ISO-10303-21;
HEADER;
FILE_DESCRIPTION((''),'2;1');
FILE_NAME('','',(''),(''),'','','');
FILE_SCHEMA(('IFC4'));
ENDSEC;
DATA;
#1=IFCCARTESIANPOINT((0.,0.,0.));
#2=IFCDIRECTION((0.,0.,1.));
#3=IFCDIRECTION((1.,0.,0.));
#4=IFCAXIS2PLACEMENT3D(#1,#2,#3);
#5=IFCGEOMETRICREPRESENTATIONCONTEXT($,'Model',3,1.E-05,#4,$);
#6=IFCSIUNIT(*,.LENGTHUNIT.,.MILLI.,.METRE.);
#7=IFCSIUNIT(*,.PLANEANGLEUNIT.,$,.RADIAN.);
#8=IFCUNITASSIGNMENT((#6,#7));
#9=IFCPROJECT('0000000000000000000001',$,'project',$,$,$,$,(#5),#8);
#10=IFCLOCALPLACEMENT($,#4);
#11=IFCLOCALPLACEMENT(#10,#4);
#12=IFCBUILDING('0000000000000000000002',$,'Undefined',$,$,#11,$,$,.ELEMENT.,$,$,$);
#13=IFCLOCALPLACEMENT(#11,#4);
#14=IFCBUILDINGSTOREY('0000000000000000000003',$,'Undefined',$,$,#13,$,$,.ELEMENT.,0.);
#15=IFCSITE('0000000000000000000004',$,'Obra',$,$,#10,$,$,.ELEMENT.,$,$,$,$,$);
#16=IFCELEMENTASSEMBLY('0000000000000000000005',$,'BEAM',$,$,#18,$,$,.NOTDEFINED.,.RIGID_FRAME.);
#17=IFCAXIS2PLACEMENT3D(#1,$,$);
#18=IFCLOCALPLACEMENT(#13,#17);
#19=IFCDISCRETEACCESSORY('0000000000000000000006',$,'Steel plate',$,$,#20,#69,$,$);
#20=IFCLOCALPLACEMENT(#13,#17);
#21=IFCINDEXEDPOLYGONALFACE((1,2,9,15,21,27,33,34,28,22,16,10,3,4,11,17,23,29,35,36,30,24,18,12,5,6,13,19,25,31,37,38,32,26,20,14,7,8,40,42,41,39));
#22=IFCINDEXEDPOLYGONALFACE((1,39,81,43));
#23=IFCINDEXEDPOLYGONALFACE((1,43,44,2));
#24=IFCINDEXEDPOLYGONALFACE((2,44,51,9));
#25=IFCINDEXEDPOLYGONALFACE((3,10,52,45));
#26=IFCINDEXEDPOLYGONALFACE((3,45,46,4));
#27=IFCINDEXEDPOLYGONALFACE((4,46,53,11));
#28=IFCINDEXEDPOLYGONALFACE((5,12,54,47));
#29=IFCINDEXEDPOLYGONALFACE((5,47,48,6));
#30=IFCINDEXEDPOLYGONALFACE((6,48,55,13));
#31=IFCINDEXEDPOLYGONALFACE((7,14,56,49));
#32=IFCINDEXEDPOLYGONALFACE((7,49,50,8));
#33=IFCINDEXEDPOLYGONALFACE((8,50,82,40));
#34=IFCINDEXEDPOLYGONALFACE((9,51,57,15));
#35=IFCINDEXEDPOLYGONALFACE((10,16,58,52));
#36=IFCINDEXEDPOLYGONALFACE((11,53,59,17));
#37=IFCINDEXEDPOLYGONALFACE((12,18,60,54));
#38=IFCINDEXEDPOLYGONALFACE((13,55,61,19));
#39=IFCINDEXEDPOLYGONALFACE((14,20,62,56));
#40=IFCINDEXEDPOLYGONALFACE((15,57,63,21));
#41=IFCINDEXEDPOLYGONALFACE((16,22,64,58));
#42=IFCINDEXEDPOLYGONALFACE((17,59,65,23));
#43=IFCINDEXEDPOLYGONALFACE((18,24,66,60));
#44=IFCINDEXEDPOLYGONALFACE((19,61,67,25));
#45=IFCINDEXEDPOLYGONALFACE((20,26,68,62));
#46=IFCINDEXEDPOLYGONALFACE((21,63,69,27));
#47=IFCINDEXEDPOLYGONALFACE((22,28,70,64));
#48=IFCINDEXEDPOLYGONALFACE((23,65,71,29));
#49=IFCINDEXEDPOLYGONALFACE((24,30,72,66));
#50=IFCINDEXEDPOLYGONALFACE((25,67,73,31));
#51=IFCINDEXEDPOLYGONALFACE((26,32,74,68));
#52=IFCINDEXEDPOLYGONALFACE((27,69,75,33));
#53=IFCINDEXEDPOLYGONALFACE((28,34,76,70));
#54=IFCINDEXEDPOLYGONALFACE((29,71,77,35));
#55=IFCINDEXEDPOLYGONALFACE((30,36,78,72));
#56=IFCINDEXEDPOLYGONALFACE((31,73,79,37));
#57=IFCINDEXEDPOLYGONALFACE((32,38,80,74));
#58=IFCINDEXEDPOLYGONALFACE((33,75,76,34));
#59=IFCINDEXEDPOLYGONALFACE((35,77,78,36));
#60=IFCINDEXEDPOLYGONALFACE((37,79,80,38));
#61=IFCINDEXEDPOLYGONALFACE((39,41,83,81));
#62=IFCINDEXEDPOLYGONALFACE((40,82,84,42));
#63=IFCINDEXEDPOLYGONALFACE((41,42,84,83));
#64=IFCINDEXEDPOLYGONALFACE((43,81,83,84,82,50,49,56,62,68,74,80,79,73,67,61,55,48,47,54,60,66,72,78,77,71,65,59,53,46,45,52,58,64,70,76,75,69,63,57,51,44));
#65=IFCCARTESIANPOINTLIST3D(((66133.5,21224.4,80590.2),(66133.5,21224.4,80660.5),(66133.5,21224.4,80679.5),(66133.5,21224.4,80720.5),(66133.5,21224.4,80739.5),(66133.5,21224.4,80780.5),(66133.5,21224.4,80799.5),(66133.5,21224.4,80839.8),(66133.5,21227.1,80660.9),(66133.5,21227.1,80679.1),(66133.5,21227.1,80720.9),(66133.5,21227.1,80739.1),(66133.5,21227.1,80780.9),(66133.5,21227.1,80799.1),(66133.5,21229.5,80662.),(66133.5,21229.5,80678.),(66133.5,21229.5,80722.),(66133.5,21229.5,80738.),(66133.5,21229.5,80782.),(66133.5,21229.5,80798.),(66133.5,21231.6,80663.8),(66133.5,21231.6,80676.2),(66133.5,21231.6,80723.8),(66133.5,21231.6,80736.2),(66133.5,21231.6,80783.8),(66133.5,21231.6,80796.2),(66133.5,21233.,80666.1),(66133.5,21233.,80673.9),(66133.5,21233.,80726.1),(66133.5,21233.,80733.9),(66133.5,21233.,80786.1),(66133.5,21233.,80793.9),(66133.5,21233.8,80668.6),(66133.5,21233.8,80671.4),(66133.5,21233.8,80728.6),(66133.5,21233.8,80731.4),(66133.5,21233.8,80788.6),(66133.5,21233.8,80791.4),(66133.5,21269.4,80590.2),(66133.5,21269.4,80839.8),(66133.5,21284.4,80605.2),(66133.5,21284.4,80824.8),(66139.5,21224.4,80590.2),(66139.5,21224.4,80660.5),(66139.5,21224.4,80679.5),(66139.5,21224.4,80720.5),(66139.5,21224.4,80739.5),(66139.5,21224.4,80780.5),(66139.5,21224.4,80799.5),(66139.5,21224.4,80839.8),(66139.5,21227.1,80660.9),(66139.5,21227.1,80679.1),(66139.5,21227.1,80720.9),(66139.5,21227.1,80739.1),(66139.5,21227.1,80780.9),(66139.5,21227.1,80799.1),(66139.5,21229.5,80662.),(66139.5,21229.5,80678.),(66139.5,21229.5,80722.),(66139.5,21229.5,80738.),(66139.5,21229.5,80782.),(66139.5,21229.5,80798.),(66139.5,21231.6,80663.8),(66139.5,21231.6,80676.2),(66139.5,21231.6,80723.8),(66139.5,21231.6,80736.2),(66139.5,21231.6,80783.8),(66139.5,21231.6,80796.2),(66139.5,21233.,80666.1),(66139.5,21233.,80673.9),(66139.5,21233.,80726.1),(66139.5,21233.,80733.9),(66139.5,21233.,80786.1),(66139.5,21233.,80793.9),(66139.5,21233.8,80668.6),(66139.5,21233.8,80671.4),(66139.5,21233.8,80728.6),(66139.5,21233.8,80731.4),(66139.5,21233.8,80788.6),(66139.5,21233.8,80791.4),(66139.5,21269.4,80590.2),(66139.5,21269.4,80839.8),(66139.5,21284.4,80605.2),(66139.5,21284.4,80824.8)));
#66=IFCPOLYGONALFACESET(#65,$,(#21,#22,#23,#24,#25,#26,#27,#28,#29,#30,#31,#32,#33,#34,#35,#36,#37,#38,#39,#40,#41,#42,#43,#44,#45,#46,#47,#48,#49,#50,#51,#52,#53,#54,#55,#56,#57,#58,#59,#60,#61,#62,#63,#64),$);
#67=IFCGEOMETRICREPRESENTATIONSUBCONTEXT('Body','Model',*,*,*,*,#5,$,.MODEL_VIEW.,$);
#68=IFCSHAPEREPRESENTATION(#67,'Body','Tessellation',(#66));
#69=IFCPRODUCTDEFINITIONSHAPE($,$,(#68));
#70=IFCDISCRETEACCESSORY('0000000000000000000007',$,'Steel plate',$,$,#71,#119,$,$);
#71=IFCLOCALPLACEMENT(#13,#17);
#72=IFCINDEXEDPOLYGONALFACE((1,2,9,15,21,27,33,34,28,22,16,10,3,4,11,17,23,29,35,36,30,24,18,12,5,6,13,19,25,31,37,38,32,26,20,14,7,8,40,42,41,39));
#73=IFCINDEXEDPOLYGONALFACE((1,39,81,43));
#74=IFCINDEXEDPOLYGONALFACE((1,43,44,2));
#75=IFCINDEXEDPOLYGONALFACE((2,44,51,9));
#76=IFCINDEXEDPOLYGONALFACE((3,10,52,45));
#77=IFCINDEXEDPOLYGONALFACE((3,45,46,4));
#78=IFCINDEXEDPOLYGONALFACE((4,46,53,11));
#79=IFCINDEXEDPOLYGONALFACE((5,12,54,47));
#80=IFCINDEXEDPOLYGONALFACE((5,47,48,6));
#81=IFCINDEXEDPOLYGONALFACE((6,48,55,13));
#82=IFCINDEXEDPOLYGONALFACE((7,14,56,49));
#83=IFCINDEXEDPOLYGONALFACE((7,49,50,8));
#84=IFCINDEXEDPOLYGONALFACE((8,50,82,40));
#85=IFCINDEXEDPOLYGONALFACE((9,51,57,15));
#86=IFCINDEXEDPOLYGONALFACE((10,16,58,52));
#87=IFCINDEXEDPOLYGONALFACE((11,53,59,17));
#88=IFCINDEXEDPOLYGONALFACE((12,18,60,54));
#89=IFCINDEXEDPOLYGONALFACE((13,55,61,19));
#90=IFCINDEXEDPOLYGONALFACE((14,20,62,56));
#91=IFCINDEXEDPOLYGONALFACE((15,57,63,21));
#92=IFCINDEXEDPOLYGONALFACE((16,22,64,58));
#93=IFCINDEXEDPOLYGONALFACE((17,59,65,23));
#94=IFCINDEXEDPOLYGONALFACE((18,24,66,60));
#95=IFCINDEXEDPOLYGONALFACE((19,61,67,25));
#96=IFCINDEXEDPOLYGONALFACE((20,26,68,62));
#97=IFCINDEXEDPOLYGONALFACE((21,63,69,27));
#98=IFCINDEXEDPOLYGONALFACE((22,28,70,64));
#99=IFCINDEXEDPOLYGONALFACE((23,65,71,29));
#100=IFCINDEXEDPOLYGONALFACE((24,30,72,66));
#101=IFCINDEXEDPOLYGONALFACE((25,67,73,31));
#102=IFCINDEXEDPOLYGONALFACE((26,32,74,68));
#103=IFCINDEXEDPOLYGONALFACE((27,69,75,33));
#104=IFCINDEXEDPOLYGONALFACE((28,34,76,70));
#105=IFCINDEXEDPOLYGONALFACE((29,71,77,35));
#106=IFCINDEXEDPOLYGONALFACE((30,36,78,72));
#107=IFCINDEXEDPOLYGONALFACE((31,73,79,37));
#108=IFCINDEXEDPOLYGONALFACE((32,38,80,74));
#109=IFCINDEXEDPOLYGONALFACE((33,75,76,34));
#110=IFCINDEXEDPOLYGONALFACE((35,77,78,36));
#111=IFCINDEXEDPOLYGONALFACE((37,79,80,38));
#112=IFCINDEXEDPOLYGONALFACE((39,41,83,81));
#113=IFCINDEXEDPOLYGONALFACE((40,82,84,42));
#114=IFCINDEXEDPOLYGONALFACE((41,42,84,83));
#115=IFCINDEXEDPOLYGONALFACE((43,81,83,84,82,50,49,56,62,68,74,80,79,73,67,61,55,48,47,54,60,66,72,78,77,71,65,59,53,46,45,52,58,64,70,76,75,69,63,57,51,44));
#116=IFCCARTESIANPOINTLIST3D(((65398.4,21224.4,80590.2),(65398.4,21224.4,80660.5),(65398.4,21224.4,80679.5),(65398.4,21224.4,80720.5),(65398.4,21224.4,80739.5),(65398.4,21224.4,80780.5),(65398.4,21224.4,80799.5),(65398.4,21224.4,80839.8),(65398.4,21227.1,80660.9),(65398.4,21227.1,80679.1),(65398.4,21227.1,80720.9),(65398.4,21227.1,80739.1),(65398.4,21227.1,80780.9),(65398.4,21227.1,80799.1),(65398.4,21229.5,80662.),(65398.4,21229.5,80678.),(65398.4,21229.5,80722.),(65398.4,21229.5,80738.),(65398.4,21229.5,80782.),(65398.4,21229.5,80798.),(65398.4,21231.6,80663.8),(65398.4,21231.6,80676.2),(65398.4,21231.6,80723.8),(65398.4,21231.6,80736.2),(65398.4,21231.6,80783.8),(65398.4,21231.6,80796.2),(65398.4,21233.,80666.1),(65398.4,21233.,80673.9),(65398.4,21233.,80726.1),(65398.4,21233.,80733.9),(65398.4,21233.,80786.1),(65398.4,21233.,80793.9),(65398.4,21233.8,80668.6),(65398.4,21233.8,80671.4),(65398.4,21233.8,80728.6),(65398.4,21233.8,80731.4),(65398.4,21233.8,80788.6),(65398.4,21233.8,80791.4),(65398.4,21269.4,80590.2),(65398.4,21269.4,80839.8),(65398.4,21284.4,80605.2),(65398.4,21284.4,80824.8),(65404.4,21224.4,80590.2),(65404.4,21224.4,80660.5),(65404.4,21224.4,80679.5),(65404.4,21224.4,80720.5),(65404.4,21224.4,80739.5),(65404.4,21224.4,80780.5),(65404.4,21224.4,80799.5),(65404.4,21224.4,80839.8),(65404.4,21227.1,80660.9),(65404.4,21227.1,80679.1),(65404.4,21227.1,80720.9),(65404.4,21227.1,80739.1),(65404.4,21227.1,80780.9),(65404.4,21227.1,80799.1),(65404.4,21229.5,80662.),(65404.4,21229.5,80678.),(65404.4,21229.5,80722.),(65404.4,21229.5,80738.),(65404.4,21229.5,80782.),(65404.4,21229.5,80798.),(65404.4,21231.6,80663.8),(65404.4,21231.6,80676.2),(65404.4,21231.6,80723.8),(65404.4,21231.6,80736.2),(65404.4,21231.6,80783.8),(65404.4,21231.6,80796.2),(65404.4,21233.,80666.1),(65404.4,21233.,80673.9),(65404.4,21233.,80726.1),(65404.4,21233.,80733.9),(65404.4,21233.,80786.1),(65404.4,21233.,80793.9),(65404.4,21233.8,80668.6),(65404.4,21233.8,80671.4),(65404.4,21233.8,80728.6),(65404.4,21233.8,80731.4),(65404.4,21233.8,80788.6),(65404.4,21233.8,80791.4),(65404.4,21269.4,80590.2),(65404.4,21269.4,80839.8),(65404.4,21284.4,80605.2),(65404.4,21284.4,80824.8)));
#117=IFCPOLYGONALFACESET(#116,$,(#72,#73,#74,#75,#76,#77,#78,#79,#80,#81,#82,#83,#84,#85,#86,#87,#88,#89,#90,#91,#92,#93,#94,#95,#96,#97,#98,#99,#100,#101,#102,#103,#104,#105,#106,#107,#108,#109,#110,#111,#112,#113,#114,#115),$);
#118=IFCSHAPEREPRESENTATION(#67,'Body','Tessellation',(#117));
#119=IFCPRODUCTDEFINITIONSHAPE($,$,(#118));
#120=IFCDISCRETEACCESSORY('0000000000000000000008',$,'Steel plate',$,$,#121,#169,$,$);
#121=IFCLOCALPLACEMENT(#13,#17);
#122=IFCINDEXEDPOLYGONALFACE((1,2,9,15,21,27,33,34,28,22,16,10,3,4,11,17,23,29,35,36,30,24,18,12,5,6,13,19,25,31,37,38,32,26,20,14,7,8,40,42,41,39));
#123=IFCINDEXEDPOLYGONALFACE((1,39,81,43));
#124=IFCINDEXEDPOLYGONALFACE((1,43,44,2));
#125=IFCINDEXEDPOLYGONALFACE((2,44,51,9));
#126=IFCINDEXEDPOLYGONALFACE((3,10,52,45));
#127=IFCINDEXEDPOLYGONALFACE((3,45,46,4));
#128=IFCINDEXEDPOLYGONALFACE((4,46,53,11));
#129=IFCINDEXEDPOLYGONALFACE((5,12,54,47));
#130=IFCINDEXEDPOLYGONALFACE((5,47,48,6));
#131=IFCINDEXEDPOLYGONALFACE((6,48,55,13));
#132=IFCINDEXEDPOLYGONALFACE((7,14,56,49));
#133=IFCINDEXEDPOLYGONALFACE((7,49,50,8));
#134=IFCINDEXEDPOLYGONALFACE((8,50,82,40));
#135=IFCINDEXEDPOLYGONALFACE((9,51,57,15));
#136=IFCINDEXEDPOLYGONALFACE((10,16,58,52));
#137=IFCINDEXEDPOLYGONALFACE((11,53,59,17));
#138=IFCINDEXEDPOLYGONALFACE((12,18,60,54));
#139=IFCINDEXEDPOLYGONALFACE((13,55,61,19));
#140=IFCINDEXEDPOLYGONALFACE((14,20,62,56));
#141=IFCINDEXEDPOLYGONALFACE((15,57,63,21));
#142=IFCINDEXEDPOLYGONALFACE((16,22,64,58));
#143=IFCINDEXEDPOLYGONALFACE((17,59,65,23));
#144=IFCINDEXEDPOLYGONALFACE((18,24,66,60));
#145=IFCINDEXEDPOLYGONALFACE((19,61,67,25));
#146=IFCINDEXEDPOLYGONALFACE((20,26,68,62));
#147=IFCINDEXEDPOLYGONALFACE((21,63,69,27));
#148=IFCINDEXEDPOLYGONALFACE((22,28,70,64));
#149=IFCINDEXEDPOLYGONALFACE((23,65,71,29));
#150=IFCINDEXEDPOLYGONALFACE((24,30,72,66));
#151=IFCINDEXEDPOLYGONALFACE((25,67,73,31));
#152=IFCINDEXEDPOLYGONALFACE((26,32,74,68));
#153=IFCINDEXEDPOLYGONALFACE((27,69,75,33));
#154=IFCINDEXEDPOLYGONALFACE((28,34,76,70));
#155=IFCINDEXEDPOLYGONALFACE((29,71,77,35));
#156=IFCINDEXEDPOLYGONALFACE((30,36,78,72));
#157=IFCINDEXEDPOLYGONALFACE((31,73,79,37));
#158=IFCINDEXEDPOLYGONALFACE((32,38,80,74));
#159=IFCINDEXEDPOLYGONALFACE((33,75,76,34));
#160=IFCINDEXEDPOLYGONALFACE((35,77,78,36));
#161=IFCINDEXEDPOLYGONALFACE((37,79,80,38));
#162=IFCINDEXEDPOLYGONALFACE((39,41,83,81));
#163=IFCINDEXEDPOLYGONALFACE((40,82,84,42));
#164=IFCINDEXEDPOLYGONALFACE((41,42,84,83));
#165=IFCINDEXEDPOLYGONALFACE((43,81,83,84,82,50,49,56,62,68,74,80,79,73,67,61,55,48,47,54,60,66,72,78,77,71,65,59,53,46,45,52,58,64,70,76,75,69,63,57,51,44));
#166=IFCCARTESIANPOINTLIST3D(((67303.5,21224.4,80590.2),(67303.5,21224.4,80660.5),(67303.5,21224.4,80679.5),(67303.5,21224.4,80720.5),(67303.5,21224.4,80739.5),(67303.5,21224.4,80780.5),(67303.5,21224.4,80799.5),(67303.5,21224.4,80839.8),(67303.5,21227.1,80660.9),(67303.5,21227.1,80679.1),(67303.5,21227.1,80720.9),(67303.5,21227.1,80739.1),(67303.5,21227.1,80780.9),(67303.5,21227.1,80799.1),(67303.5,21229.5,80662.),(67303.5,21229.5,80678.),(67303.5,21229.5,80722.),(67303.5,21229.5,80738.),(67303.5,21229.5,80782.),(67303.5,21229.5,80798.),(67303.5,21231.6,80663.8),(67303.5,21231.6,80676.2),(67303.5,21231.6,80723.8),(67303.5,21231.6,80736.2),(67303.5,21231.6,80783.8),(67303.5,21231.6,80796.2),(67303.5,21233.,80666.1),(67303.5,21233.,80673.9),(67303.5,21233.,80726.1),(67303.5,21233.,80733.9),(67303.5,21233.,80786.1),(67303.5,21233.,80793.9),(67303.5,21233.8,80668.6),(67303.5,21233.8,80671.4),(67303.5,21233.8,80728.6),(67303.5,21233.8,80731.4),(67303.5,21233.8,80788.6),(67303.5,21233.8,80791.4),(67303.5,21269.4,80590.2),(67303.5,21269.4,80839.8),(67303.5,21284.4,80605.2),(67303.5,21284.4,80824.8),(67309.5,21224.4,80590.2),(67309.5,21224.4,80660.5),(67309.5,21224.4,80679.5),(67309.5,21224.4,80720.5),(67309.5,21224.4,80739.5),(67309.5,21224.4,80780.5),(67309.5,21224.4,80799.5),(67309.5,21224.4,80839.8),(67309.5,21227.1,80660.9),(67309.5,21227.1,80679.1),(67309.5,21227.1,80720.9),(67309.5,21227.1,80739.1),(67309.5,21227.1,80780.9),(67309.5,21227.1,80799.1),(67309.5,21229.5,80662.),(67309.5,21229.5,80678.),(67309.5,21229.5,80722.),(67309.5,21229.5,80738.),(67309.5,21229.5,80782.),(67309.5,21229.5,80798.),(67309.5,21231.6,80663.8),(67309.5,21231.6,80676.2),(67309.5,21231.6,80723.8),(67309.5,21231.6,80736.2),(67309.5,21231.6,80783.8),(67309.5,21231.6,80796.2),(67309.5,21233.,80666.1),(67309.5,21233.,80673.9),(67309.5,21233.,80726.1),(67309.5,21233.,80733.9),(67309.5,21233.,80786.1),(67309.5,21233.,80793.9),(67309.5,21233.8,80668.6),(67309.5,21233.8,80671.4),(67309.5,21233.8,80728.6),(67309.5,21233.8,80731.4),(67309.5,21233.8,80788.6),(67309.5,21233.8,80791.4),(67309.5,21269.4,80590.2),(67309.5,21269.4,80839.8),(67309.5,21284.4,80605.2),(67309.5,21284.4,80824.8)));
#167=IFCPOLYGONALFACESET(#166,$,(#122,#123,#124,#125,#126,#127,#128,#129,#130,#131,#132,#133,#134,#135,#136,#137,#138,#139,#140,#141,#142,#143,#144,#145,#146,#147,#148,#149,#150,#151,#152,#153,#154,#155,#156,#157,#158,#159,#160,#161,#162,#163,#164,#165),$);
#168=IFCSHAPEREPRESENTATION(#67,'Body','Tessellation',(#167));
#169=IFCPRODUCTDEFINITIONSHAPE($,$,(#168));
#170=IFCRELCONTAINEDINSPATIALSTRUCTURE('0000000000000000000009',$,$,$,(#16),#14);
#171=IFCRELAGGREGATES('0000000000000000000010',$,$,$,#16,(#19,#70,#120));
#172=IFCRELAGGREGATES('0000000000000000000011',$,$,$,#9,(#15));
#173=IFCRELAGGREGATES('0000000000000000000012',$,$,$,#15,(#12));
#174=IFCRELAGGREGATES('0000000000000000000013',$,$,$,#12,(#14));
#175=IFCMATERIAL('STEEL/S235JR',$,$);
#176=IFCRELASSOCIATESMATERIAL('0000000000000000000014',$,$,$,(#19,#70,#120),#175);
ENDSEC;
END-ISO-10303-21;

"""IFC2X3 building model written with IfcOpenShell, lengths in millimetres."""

from ifc_helpers import new_model, si_unit, frame, origin_with_axes, origin_2d_with_axis, place, context, subcontext, project, spatial, polyline, circle, outline, extrude, source, transform, mapped, material, element, aggregate, save


model = new_model("IFC2X3")

# Units and contexts
model_context = context("Model", 3, precision=1e-05, world=origin_with_axes())
body_context = subcontext(model_context, "Body", "Model", "MODEL_VIEW")
ifc_project = project(units=[si_unit("LENGTHUNIT", "METRE", prefix="MILLI"), si_unit("PLANEANGLEUNIT", "RADIAN")], contexts=[model_context])

# Site, building, storey
site_placement = place(None, origin_with_axes())
site = spatial("IfcSite", under=ifc_project, at=site_placement, Name="Obra", CompositionType="ELEMENT")
building_placement = place(site_placement, origin_with_axes())
building = spatial("IfcBuilding", under=site, at=building_placement, Name="Undefined", CompositionType="ELEMENT")
storey_placement = place(building_placement, origin_with_axes())
storey = spatial("IfcBuildingStorey", under=building, at=storey_placement, Name="Undefined", CompositionType="ELEMENT", Elevation=0.0)

# Shared definitions
ifc_material = material(Name="STEEL/S235JR")

# Element assembly, discrete accessories, openings
assembly_1_placement = place(storey_placement, origin_with_axes())
assembly_1 = element("IfcElementAssembly", 1, at=assembly_1_placement, inside=storey, Name="BEAM", AssemblyPlace="NOTDEFINED", PredefinedType="RIGID_FRAME")
discrete_accessory_1_placement = place(assembly_1_placement, frame((66136.5, 21224.4, 80590.2), z_axis=(1.0, 0.000001, 0.0), x_axis=(-0.000001, 1.0, 0.0)))
discrete_accessory_1 = element("IfcDiscreteAccessory", 2, at=discrete_accessory_1_placement, material=ifc_material, Name="Steel plate", context=body_context, shape_type="SweptSolid", body=[
    extrude(outline(polyline([(0.0, 0.0), (45.0, 0.0), (60.0, 15.0), (60.0, 234.6), (45.0, 249.6), (0.0, 249.6), (0.0, 0.0)])), frame((0.0, 0.0, -3.0), z_axis=(0.0, 0.0, 1.0), x_axis=(1.0, 0.0, 0.0)), (0.0, 0.0, 1.0), 6.0),
])
shared_shape_1 = source(origin_with_axes(), body_context, "Body", "SweptSolid", [
    extrude(circle(Radius=9.5, at=origin_2d_with_axis()), frame((0.0, -9.2, 0.0), z_axis=(0.0, 1.0, 0.0), x_axis=(1.0, 0.0, 0.0)), (0.0, 0.0, 1.0), 6.2),
])
opening_1_placement = place(assembly_1_placement, frame((66142.6, 21274.4, 80850.0), z_axis=(0.000001, -1.0, 0.0), x_axis=(0.0, 0.0, -1.0)))
element("IfcOpeningElement", 3, at=opening_1_placement, cuts=discrete_accessory_1, ObjectType="Opening", context=body_context, shape_type="MappedRepresentation", body=[
    mapped(shared_shape_1, transform((60.0, 0.0, 50.0))),
    mapped(shared_shape_1, transform((120.0, 0.0, 50.0))),
    mapped(shared_shape_1, transform((180.0, 0.0, 50.0))),
])
discrete_accessory_2_placement = place(assembly_1_placement, frame((65401.4, 21224.4, 80590.2), z_axis=(1.0, 0.000001, 0.0), x_axis=(-0.000001, 1.0, 0.0)))
discrete_accessory_2 = element("IfcDiscreteAccessory", 4, at=discrete_accessory_2_placement, material=ifc_material, Name="Steel plate", context=body_context, shape_type="SweptSolid", body=[
    extrude(outline(polyline([(0.0, 0.0), (45.0, 0.0), (60.0, 15.0), (60.0, 234.6), (45.0, 249.6), (0.0, 249.6), (0.0, 0.0)])), frame((0.0, 0.0, -3.0), z_axis=(0.0, 0.0, 1.0), x_axis=(1.0, 0.0, 0.0)), (0.0, 0.0, 1.0), 6.0),
])
opening_2_placement = place(assembly_1_placement, frame((65407.5, 21274.4, 80850.0), z_axis=(0.000001, -1.0, 0.0), x_axis=(0.0, 0.0, -1.0)))
element("IfcOpeningElement", 5, at=opening_2_placement, cuts=discrete_accessory_2, ObjectType="Opening", context=body_context, shape_type="MappedRepresentation", body=[
    mapped(shared_shape_1, transform((60.0, 0.0, 50.0))),
    mapped(shared_shape_1, transform((120.0, 0.0, 50.0))),
    mapped(shared_shape_1, transform((180.0, 0.0, 50.0))),
])
discrete_accessory_3_placement = place(assembly_1_placement, frame((67306.5, 21224.4, 80590.2), z_axis=(1.0, 0.000001, 0.0), x_axis=(-0.000001, 1.0, 0.0)))
discrete_accessory_3 = element("IfcDiscreteAccessory", 6, at=discrete_accessory_3_placement, material=ifc_material, Name="Steel plate", context=body_context, shape_type="SweptSolid", body=[
    extrude(outline(polyline([(0.0, 0.0), (45.0, 0.0), (60.0, 15.0), (60.0, 234.6), (45.0, 249.6), (0.0, 249.6), (0.0, 0.0)])), frame((0.0, 0.0, -3.0), z_axis=(0.0, 0.0, 1.0), x_axis=(1.0, 0.0, 0.0)), (0.0, 0.0, 1.0), 6.0),
])
opening_3_placement = place(assembly_1_placement, frame((67312.6, 21274.4, 80850.0), z_axis=(0.000001, -1.0, 0.0), x_axis=(0.0, 0.0, -1.0)))
element("IfcOpeningElement", 7, at=opening_3_placement, cuts=discrete_accessory_3, ObjectType="Opening", context=body_context, shape_type="MappedRepresentation", body=[
    mapped(shared_shape_1, transform((60.0, 0.0, 50.0))),
    mapped(shared_shape_1, transform((120.0, 0.0, 50.0))),
    mapped(shared_shape_1, transform((180.0, 0.0, 50.0))),
])
aggregate(assembly_1, [discrete_accessory_1, discrete_accessory_2, discrete_accessory_3])

save(model, "model.ifc")
